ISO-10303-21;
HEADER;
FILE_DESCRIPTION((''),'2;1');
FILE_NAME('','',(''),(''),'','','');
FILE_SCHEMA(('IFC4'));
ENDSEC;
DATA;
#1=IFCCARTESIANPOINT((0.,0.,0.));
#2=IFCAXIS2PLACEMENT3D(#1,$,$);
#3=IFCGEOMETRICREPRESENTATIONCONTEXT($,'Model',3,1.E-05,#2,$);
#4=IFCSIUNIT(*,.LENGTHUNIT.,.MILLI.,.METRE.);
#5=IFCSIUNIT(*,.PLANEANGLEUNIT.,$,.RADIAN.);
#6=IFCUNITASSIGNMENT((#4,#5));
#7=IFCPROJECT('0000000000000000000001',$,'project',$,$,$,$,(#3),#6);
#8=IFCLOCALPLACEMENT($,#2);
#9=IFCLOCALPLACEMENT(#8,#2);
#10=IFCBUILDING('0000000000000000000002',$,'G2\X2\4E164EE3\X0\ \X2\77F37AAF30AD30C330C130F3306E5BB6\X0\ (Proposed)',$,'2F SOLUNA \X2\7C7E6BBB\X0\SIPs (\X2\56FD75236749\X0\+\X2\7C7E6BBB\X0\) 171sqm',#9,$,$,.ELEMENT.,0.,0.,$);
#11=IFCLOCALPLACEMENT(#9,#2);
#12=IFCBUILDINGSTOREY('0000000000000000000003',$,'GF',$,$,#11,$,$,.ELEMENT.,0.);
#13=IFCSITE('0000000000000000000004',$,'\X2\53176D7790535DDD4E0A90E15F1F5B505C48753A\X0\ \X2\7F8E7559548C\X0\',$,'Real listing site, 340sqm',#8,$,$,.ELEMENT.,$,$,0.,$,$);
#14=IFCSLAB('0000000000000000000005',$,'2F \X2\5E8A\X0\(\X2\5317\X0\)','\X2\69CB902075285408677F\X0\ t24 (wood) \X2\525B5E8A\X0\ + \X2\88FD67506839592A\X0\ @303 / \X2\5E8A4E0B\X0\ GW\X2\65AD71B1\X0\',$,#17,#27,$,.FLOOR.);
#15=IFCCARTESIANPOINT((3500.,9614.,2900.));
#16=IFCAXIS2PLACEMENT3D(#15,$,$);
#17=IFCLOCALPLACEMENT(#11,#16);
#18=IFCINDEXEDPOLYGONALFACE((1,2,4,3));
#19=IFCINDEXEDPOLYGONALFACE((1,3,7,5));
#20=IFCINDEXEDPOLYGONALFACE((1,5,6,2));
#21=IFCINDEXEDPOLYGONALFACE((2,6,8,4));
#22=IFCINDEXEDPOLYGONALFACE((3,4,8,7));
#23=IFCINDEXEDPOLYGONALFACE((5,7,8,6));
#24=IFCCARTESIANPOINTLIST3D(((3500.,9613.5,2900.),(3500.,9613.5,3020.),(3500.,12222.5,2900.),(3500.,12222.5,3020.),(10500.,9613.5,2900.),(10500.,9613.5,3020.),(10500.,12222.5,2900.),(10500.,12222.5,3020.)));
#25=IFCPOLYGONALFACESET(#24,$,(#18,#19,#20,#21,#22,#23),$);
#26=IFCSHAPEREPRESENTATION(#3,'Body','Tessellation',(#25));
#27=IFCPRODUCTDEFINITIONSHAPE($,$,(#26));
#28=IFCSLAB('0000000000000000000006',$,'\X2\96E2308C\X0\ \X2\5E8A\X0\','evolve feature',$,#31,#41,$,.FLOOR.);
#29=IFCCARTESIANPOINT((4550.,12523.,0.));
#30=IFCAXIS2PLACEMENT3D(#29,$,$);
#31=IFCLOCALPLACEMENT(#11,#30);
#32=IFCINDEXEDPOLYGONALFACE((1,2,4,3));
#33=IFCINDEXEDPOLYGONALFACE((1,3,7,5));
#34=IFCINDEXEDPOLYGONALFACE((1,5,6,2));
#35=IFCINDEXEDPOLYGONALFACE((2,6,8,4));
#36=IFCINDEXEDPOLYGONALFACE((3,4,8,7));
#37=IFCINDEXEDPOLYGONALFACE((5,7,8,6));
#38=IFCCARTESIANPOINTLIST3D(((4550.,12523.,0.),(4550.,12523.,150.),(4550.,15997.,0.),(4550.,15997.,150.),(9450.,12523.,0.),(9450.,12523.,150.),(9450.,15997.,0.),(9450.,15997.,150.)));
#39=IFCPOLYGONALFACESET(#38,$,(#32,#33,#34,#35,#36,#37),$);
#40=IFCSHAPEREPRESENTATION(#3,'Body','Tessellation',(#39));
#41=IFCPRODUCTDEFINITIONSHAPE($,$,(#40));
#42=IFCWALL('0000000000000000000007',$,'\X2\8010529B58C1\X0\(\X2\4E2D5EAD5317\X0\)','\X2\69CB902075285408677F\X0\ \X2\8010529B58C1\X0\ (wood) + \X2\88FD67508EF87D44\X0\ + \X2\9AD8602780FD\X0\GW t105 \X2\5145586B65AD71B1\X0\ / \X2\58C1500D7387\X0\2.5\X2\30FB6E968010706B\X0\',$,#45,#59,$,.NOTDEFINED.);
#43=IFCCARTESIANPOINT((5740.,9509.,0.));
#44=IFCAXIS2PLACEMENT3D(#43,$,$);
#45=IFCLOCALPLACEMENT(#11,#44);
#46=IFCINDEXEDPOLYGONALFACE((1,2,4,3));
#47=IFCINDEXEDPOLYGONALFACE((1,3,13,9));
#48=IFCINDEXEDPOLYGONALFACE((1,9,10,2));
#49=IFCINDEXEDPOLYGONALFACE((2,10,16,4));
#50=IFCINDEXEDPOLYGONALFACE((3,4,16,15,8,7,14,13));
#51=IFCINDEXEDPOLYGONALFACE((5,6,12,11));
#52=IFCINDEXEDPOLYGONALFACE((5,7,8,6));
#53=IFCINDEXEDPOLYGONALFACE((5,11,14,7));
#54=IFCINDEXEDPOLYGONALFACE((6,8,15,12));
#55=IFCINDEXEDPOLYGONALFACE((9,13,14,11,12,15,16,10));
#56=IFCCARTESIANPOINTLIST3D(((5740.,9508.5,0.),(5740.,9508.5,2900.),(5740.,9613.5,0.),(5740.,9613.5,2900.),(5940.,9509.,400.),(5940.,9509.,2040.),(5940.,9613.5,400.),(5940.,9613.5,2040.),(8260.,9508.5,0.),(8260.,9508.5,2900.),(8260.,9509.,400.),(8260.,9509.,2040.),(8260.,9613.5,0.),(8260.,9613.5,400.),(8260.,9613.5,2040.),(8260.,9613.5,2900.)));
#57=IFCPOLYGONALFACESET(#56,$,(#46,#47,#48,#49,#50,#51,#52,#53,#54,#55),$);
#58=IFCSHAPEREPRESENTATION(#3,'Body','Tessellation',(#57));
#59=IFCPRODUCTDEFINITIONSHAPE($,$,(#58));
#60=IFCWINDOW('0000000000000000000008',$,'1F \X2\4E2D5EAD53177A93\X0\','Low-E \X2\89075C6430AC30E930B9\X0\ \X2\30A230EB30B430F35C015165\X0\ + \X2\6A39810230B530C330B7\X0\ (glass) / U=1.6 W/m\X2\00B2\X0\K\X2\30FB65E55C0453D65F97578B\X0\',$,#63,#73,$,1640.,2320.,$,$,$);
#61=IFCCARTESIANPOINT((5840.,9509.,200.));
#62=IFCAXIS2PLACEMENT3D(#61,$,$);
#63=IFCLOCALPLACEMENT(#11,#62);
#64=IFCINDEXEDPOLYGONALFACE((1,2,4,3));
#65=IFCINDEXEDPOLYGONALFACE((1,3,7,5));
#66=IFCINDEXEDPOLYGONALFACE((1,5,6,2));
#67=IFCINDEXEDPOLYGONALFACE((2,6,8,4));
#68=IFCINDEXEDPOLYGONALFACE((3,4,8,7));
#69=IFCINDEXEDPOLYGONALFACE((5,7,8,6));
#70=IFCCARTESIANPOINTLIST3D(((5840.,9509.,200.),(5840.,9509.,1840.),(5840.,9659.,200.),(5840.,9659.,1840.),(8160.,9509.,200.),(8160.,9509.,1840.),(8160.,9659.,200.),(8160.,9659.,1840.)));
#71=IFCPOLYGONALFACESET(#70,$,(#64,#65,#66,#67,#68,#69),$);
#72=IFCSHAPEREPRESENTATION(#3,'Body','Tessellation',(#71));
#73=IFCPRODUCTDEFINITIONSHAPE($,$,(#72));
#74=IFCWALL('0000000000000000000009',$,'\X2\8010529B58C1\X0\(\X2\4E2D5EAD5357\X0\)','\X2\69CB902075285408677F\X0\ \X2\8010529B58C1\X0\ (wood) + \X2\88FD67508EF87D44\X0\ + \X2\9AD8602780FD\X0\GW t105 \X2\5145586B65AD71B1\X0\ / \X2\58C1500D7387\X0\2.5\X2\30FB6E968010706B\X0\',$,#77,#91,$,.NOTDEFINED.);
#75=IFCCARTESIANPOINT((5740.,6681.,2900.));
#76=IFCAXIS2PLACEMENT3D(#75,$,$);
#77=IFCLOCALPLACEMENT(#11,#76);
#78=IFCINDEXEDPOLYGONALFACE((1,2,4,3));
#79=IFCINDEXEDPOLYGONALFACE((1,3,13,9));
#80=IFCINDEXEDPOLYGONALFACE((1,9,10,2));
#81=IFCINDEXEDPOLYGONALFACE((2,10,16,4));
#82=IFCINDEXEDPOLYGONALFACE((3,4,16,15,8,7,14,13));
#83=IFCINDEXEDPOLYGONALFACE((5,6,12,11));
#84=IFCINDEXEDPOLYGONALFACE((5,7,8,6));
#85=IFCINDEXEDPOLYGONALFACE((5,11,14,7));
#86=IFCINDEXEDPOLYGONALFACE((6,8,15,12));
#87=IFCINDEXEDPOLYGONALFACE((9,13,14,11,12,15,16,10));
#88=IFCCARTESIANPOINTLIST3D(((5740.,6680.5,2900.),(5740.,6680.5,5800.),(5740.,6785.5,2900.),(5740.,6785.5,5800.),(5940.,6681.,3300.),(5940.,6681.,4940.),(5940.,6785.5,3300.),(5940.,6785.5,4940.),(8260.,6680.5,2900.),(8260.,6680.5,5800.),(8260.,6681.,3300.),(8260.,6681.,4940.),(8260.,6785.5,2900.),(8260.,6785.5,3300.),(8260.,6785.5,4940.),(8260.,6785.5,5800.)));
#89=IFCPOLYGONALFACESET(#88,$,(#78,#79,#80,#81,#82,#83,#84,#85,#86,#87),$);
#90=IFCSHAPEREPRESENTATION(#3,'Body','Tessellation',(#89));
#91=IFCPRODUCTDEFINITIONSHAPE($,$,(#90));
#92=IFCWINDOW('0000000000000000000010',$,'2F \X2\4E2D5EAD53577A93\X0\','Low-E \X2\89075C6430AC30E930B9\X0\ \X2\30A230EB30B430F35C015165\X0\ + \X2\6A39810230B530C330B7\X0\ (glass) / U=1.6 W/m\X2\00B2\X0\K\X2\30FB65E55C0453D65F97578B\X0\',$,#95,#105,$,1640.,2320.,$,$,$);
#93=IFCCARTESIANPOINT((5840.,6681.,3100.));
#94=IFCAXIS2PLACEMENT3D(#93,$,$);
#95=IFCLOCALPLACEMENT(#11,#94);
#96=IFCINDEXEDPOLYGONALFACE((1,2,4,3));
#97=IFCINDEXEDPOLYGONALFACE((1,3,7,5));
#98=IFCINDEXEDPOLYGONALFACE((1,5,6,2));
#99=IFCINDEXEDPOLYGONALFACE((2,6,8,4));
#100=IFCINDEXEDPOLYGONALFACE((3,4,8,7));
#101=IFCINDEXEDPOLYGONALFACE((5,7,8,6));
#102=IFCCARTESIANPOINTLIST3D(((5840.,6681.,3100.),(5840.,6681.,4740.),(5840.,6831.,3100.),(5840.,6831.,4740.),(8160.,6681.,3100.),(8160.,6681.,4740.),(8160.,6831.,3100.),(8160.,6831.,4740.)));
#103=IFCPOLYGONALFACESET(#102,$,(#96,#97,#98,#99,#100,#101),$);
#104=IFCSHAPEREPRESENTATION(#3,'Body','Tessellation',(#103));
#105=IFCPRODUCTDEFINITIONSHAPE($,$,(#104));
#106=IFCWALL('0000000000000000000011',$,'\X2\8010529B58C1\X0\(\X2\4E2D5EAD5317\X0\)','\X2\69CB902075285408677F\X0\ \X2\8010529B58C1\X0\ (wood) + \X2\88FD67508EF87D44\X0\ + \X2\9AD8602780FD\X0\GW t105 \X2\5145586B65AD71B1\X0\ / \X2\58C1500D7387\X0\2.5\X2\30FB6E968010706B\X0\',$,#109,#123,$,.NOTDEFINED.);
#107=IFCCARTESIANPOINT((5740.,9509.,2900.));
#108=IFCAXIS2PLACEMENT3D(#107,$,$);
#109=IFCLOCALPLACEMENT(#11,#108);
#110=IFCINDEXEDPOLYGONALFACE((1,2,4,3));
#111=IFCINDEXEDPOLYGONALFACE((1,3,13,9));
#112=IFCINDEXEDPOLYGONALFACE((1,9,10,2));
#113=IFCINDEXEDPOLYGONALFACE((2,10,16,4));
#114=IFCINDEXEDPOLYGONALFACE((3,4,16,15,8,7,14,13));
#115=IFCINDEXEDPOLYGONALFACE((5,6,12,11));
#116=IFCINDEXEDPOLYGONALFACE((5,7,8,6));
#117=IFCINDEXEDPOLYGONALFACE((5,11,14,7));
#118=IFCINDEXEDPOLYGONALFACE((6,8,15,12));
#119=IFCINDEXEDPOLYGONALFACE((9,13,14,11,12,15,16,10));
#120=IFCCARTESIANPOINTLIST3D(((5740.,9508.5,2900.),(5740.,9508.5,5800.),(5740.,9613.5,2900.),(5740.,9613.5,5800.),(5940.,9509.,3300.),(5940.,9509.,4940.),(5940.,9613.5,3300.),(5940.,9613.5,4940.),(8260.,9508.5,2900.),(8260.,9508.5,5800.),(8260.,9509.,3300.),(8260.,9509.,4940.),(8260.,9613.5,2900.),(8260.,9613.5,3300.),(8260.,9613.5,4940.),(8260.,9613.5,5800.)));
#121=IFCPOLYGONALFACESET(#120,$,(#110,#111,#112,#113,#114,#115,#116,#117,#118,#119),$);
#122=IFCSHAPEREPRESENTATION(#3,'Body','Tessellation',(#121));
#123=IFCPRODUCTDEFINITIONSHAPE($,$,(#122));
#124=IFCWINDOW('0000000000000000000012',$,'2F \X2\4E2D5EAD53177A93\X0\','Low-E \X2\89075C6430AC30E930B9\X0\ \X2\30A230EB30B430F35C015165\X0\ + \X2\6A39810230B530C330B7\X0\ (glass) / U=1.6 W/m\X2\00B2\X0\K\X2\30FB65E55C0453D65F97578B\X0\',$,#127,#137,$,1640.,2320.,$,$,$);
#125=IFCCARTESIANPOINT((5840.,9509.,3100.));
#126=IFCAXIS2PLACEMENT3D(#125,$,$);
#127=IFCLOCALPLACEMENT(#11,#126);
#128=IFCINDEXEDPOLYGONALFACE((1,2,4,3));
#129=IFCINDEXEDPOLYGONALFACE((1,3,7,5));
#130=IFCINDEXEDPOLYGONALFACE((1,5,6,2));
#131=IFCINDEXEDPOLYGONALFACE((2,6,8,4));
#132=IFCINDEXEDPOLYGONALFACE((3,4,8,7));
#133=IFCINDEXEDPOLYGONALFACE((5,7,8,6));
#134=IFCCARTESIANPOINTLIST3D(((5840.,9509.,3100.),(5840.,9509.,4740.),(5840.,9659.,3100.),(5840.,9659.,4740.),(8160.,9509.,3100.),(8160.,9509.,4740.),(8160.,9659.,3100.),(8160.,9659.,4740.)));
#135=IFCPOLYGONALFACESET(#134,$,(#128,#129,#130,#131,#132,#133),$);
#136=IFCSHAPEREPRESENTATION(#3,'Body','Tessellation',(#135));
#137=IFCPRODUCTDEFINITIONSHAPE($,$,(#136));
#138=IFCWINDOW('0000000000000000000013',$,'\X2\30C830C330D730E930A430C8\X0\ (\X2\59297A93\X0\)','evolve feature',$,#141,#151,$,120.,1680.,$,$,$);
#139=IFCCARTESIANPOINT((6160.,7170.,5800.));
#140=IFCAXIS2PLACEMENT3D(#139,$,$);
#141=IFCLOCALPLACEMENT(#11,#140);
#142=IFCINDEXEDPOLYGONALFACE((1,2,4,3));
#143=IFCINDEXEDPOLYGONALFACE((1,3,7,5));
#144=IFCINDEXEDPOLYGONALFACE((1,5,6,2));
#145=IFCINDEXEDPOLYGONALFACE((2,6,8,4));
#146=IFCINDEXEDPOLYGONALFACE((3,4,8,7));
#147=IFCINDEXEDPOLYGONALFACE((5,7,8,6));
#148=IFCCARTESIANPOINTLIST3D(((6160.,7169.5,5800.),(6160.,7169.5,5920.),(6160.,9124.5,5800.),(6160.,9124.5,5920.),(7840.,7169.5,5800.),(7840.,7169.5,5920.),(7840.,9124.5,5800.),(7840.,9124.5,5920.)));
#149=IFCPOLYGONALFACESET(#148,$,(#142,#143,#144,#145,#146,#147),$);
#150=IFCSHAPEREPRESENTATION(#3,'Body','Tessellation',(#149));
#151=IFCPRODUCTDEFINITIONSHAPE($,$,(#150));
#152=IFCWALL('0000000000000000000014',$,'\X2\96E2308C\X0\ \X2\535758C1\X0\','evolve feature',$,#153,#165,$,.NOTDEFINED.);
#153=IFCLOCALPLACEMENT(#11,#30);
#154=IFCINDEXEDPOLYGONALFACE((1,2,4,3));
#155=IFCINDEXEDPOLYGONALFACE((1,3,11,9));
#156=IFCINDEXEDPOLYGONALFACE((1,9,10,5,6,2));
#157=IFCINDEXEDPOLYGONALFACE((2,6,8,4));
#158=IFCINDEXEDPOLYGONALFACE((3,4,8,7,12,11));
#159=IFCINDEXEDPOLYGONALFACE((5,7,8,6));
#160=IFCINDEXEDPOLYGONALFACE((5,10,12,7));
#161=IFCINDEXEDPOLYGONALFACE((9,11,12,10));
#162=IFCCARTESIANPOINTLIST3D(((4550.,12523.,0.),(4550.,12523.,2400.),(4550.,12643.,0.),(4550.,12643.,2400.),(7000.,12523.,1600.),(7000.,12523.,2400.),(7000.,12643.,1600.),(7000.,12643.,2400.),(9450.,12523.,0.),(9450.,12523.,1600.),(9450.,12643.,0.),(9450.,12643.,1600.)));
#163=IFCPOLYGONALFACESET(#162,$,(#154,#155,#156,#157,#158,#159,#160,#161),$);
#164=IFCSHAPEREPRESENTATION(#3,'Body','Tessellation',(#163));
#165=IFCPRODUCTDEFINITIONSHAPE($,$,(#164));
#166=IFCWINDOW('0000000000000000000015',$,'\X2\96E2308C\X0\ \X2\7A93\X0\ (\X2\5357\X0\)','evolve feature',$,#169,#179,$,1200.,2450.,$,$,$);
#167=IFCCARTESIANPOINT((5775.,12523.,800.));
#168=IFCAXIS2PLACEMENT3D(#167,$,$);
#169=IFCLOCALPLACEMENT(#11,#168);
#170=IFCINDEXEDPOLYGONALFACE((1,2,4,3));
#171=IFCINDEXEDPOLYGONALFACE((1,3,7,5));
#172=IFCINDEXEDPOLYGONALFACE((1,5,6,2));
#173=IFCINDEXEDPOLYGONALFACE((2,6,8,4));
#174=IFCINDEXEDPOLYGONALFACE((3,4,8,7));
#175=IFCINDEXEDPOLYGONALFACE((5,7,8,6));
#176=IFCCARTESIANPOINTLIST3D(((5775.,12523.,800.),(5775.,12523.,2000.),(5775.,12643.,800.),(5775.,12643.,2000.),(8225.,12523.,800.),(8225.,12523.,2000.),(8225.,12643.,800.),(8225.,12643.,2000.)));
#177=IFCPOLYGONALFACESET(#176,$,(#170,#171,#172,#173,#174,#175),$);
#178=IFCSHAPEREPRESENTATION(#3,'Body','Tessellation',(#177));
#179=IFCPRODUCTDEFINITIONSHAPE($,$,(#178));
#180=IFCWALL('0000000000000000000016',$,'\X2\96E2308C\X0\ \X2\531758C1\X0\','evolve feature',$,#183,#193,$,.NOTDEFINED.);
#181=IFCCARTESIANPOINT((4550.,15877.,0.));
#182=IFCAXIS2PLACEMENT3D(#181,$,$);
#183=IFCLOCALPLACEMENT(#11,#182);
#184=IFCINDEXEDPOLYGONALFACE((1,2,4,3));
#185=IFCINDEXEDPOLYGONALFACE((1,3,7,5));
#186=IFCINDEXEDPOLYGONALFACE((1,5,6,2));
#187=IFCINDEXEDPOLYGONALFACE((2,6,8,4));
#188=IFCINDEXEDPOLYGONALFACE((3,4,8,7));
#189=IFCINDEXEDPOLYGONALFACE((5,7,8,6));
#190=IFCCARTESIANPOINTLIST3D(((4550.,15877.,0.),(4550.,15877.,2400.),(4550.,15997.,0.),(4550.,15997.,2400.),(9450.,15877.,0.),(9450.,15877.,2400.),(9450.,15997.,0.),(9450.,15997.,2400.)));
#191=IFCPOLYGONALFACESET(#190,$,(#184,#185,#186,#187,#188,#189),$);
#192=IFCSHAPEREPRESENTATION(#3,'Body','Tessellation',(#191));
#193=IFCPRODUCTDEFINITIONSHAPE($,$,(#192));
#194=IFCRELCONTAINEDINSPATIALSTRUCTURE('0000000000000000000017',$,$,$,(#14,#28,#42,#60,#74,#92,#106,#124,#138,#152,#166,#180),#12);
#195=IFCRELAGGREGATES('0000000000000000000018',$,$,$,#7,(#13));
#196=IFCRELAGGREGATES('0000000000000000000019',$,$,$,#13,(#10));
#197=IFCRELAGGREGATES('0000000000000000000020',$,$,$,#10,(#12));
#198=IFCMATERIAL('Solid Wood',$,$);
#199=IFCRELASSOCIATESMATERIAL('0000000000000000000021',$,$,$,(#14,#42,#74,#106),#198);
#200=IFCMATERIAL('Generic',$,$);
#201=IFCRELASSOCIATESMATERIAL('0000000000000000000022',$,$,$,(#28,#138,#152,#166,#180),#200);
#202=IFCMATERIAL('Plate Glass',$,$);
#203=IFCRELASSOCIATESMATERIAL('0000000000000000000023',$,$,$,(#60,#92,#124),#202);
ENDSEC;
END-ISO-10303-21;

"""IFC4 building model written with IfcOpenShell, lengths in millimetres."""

from ifc_helpers import new_model, si_unit, frame, frame_2d, origin, place, context, project, spatial, rectangle, extrude, material, element, fill, save


model = new_model("IFC4")

# Units and contexts
model_context = context("Model", 3, precision=1e-05, world=origin())
ifc_project = project(units=[si_unit("LENGTHUNIT", "METRE", prefix="MILLI"), si_unit("PLANEANGLEUNIT", "RADIAN")], contexts=[model_context])

# Site, building, storey
site_placement = place(None, origin())
site = spatial("IfcSite", under=ifc_project, at=site_placement, Name="北海道川上郡弟子屈町 美留和", ObjectType="Real listing site, 340sqm", CompositionType="ELEMENT", RefElevation=0.0)
building_placement = place(site_placement, origin())
building = spatial("IfcBuilding", under=site, at=building_placement, Name="G2世代 石窯キッチンの家 (Proposed)", ObjectType="2F SOLUNA 籾殻SIPs (国産杉+籾殻) 171sqm", CompositionType="ELEMENT", ElevationOfRefHeight=0.0, ElevationOfTerrain=0.0)
storey_placement = place(building_placement, origin())
storey = spatial("IfcBuildingStorey", under=building, at=storey_placement, Name="GF", CompositionType="ELEMENT", Elevation=0.0)

# Slabs
ifc_material_1 = material(Name="Solid Wood")
slab_1_placement = place(storey_placement, frame((3500.0, 9614.0, 2900.0)))
element("IfcSlab", 1, at=slab_1_placement, inside=storey, material=ifc_material_1, Name="2F 床(北)", Description="構造用合板 t24 (wood) 剛床 + 製材根太 @303 / 床下 GW断熱", PredefinedType="FLOOR", context=model_context, shape_type="SweptSolid", body=[
    extrude(rectangle(XDim=7000.0, YDim=2609.0, at=frame_2d((3500.0, 1304.0))), frame((3500.0, 9614.0, 2900.0)), (0.0, 0.0, 1.0), 120.0),
])
ifc_material_2 = material(Name="Generic")
slab_2_placement = place(storey_placement, frame((4550.0, 12523.0, 0.0)))
element("IfcSlab", 2, at=slab_2_placement, inside=storey, material=ifc_material_2, Name="離れ 床", Description="evolve feature", PredefinedType="FLOOR", context=model_context, shape_type="SweptSolid", body=[
    extrude(rectangle(XDim=4900.0, YDim=3474.0, at=frame_2d((2450.0, 1737.0))), frame((4550.0, 12523.0, 0.0)), (0.0, 0.0, 1.0), 150.0),
])

# Wall, opening, window
wall_1_placement = place(storey_placement, frame((5740.0, 9509.0, 0.0)))
wall_1 = element("IfcWall", 3, at=wall_1_placement, inside=storey, material=ifc_material_1, Name="耐力壁(中庭北)", Description="構造用合板 耐力壁 (wood) + 製材軸組 + 高性能GW t105 充填断熱 / 壁倍率2.5・準耐火", PredefinedType="NOTDEFINED", context=model_context, shape_type="SweptSolid", body=[
    extrude(rectangle(XDim=2520.0, YDim=105.0, at=frame_2d((1260.0, 52.0))), frame((5740.0, 9509.0, 0.0)), (0.0, 0.0, 1.0), 2900.0),
])
opening_1_placement = place(storey_placement, frame((5840.0, 9509.0, 200.0)))
opening_1 = element("IfcOpeningElement", 4, at=opening_1_placement, cuts=wall_1, PredefinedType="NOTDEFINED", context=model_context, shape_type="SweptSolid", body=[
    extrude(rectangle(XDim=2320.0, YDim=150.0, at=frame_2d((1160.0, 75.0))), frame((5840.0, 9509.0, 200.0)), (0.0, 0.0, 1.0), 1640.0),
])
ifc_material_3 = material(Name="Plate Glass")
window_1_placement = place(storey_placement, frame((5840.0, 9509.0, 200.0)))
window_1 = element("IfcWindow", 5, at=window_1_placement, inside=storey, material=ifc_material_3, Name="1F 中庭北窓", Description="Low-E 複層ガラス アルゴン封入 + 樹脂サッシ (glass) / U=1.6 W/m²K・日射取得型", OverallHeight=1640.0, OverallWidth=2320.0, context=model_context, shape_type="SweptSolid", body=[
    extrude(rectangle(XDim=2320.0, YDim=150.0, at=frame_2d((1160.0, 75.0))), frame((5840.0, 9509.0, 200.0)), (0.0, 0.0, 1.0), 1640.0),
])
fill(opening_1, window_1)

# Walls, openings, windows
wall_2_placement = place(storey_placement, frame((5740.0, 6681.0, 2900.0)))
wall_2 = element("IfcWall", 6, at=wall_2_placement, inside=storey, material=ifc_material_1, Name="耐力壁(中庭南)", Description="構造用合板 耐力壁 (wood) + 製材軸組 + 高性能GW t105 充填断熱 / 壁倍率2.5・準耐火", PredefinedType="NOTDEFINED", context=model_context, shape_type="SweptSolid", body=[
    extrude(rectangle(XDim=2520.0, YDim=105.0, at=frame_2d((1260.0, 52.0))), frame((5740.0, 6681.0, 2900.0)), (0.0, 0.0, 1.0), 2900.0),
])
opening_2_placement = place(storey_placement, frame((5840.0, 6681.0, 3100.0)))
opening_2 = element("IfcOpeningElement", 7, at=opening_2_placement, cuts=wall_2, PredefinedType="NOTDEFINED", context=model_context, shape_type="SweptSolid", body=[
    extrude(rectangle(XDim=2320.0, YDim=150.0, at=frame_2d((1160.0, 75.0))), frame((5840.0, 6681.0, 3100.0)), (0.0, 0.0, 1.0), 1640.0),
])
window_2_placement = place(storey_placement, frame((5840.0, 6681.0, 3100.0)))
window_2 = element("IfcWindow", 8, at=window_2_placement, inside=storey, material=ifc_material_3, Name="2F 中庭南窓", Description="Low-E 複層ガラス アルゴン封入 + 樹脂サッシ (glass) / U=1.6 W/m²K・日射取得型", OverallHeight=1640.0, OverallWidth=2320.0, context=model_context, shape_type="SweptSolid", body=[
    extrude(rectangle(XDim=2320.0, YDim=150.0, at=frame_2d((1160.0, 75.0))), frame((5840.0, 6681.0, 3100.0)), (0.0, 0.0, 1.0), 1640.0),
])
fill(opening_2, window_2)
wall_3_placement = place(storey_placement, frame((5740.0, 9509.0, 2900.0)))
wall_3 = element("IfcWall", 9, at=wall_3_placement, inside=storey, material=ifc_material_1, Name="耐力壁(中庭北)", Description="構造用合板 耐力壁 (wood) + 製材軸組 + 高性能GW t105 充填断熱 / 壁倍率2.5・準耐火", PredefinedType="NOTDEFINED", context=model_context, shape_type="SweptSolid", body=[
    extrude(rectangle(XDim=2520.0, YDim=105.0, at=frame_2d((1260.0, 52.0))), frame((5740.0, 9509.0, 2900.0)), (0.0, 0.0, 1.0), 2900.0),
])
opening_3_placement = place(storey_placement, frame((5840.0, 9509.0, 3100.0)))
opening_3 = element("IfcOpeningElement", 10, at=opening_3_placement, cuts=wall_3, PredefinedType="NOTDEFINED", context=model_context, shape_type="SweptSolid", body=[
    extrude(rectangle(XDim=2320.0, YDim=150.0, at=frame_2d((1160.0, 75.0))), frame((5840.0, 9509.0, 3100.0)), (0.0, 0.0, 1.0), 1640.0),
])
window_3_placement = place(storey_placement, frame((5840.0, 9509.0, 3100.0)))
window_3 = element("IfcWindow", 11, at=window_3_placement, inside=storey, material=ifc_material_3, Name="2F 中庭北窓", Description="Low-E 複層ガラス アルゴン封入 + 樹脂サッシ (glass) / U=1.6 W/m²K・日射取得型", OverallHeight=1640.0, OverallWidth=2320.0, context=model_context, shape_type="SweptSolid", body=[
    extrude(rectangle(XDim=2320.0, YDim=150.0, at=frame_2d((1160.0, 75.0))), frame((5840.0, 9509.0, 3100.0)), (0.0, 0.0, 1.0), 1640.0),
])
fill(opening_3, window_3)

# Window
window_4_placement = place(storey_placement, frame((6160.0, 7170.0, 5800.0)))
element("IfcWindow", 12, at=window_4_placement, inside=storey, material=ifc_material_2, Name="トップライト (天窓)", Description="evolve feature", OverallHeight=120.0, OverallWidth=1680.0, context=model_context, shape_type="SweptSolid", body=[
    extrude(rectangle(XDim=1680.0, YDim=1955.0, at=frame_2d((840.0, 977.0))), frame((6160.0, 7170.0, 5800.0)), (0.0, 0.0, 1.0), 120.0),
])

# Wall, opening, window
wall_4_placement = place(storey_placement, frame((4550.0, 12523.0, 0.0)))
wall_4 = element("IfcWall", 13, at=wall_4_placement, inside=storey, material=ifc_material_2, Name="離れ 南壁", Description="evolve feature", PredefinedType="NOTDEFINED", context=model_context, shape_type="SweptSolid", body=[
    extrude(rectangle(XDim=4900.0, YDim=120.0, at=frame_2d((2450.0, 60.0))), frame((4550.0, 12523.0, 0.0)), (0.0, 0.0, 1.0), 2400.0),
])
opening_4_placement = place(storey_placement, frame((5775.0, 12523.0, 800.0)))
opening_4 = element("IfcOpeningElement", 14, at=opening_4_placement, cuts=wall_4, PredefinedType="NOTDEFINED", context=model_context, shape_type="SweptSolid", body=[
    extrude(rectangle(XDim=2450.0, YDim=120.0, at=frame_2d((1225.0, 60.0))), frame((5775.0, 12523.0, 800.0)), (0.0, 0.0, 1.0), 1200.0),
])
window_5_placement = place(storey_placement, frame((5775.0, 12523.0, 800.0)))
window_5 = element("IfcWindow", 15, at=window_5_placement, inside=storey, material=ifc_material_2, Name="離れ 窓 (南)", Description="evolve feature", OverallHeight=1200.0, OverallWidth=2450.0, context=model_context, shape_type="SweptSolid", body=[
    extrude(rectangle(XDim=2450.0, YDim=120.0, at=frame_2d((1225.0, 60.0))), frame((5775.0, 12523.0, 800.0)), (0.0, 0.0, 1.0), 1200.0),
])
fill(opening_4, window_5)

# Wall
wall_5_placement = place(storey_placement, frame((4550.0, 15877.0, 0.0)))
element("IfcWall", 16, at=wall_5_placement, inside=storey, material=ifc_material_2, Name="離れ 北壁", Description="evolve feature", PredefinedType="NOTDEFINED", context=model_context, shape_type="SweptSolid", body=[
    extrude(rectangle(XDim=4900.0, YDim=120.0, at=frame_2d((2450.0, 60.0))), frame((4550.0, 15877.0, 0.0)), (0.0, 0.0, 1.0), 2400.0),
])

save(model, "model.ifc")
